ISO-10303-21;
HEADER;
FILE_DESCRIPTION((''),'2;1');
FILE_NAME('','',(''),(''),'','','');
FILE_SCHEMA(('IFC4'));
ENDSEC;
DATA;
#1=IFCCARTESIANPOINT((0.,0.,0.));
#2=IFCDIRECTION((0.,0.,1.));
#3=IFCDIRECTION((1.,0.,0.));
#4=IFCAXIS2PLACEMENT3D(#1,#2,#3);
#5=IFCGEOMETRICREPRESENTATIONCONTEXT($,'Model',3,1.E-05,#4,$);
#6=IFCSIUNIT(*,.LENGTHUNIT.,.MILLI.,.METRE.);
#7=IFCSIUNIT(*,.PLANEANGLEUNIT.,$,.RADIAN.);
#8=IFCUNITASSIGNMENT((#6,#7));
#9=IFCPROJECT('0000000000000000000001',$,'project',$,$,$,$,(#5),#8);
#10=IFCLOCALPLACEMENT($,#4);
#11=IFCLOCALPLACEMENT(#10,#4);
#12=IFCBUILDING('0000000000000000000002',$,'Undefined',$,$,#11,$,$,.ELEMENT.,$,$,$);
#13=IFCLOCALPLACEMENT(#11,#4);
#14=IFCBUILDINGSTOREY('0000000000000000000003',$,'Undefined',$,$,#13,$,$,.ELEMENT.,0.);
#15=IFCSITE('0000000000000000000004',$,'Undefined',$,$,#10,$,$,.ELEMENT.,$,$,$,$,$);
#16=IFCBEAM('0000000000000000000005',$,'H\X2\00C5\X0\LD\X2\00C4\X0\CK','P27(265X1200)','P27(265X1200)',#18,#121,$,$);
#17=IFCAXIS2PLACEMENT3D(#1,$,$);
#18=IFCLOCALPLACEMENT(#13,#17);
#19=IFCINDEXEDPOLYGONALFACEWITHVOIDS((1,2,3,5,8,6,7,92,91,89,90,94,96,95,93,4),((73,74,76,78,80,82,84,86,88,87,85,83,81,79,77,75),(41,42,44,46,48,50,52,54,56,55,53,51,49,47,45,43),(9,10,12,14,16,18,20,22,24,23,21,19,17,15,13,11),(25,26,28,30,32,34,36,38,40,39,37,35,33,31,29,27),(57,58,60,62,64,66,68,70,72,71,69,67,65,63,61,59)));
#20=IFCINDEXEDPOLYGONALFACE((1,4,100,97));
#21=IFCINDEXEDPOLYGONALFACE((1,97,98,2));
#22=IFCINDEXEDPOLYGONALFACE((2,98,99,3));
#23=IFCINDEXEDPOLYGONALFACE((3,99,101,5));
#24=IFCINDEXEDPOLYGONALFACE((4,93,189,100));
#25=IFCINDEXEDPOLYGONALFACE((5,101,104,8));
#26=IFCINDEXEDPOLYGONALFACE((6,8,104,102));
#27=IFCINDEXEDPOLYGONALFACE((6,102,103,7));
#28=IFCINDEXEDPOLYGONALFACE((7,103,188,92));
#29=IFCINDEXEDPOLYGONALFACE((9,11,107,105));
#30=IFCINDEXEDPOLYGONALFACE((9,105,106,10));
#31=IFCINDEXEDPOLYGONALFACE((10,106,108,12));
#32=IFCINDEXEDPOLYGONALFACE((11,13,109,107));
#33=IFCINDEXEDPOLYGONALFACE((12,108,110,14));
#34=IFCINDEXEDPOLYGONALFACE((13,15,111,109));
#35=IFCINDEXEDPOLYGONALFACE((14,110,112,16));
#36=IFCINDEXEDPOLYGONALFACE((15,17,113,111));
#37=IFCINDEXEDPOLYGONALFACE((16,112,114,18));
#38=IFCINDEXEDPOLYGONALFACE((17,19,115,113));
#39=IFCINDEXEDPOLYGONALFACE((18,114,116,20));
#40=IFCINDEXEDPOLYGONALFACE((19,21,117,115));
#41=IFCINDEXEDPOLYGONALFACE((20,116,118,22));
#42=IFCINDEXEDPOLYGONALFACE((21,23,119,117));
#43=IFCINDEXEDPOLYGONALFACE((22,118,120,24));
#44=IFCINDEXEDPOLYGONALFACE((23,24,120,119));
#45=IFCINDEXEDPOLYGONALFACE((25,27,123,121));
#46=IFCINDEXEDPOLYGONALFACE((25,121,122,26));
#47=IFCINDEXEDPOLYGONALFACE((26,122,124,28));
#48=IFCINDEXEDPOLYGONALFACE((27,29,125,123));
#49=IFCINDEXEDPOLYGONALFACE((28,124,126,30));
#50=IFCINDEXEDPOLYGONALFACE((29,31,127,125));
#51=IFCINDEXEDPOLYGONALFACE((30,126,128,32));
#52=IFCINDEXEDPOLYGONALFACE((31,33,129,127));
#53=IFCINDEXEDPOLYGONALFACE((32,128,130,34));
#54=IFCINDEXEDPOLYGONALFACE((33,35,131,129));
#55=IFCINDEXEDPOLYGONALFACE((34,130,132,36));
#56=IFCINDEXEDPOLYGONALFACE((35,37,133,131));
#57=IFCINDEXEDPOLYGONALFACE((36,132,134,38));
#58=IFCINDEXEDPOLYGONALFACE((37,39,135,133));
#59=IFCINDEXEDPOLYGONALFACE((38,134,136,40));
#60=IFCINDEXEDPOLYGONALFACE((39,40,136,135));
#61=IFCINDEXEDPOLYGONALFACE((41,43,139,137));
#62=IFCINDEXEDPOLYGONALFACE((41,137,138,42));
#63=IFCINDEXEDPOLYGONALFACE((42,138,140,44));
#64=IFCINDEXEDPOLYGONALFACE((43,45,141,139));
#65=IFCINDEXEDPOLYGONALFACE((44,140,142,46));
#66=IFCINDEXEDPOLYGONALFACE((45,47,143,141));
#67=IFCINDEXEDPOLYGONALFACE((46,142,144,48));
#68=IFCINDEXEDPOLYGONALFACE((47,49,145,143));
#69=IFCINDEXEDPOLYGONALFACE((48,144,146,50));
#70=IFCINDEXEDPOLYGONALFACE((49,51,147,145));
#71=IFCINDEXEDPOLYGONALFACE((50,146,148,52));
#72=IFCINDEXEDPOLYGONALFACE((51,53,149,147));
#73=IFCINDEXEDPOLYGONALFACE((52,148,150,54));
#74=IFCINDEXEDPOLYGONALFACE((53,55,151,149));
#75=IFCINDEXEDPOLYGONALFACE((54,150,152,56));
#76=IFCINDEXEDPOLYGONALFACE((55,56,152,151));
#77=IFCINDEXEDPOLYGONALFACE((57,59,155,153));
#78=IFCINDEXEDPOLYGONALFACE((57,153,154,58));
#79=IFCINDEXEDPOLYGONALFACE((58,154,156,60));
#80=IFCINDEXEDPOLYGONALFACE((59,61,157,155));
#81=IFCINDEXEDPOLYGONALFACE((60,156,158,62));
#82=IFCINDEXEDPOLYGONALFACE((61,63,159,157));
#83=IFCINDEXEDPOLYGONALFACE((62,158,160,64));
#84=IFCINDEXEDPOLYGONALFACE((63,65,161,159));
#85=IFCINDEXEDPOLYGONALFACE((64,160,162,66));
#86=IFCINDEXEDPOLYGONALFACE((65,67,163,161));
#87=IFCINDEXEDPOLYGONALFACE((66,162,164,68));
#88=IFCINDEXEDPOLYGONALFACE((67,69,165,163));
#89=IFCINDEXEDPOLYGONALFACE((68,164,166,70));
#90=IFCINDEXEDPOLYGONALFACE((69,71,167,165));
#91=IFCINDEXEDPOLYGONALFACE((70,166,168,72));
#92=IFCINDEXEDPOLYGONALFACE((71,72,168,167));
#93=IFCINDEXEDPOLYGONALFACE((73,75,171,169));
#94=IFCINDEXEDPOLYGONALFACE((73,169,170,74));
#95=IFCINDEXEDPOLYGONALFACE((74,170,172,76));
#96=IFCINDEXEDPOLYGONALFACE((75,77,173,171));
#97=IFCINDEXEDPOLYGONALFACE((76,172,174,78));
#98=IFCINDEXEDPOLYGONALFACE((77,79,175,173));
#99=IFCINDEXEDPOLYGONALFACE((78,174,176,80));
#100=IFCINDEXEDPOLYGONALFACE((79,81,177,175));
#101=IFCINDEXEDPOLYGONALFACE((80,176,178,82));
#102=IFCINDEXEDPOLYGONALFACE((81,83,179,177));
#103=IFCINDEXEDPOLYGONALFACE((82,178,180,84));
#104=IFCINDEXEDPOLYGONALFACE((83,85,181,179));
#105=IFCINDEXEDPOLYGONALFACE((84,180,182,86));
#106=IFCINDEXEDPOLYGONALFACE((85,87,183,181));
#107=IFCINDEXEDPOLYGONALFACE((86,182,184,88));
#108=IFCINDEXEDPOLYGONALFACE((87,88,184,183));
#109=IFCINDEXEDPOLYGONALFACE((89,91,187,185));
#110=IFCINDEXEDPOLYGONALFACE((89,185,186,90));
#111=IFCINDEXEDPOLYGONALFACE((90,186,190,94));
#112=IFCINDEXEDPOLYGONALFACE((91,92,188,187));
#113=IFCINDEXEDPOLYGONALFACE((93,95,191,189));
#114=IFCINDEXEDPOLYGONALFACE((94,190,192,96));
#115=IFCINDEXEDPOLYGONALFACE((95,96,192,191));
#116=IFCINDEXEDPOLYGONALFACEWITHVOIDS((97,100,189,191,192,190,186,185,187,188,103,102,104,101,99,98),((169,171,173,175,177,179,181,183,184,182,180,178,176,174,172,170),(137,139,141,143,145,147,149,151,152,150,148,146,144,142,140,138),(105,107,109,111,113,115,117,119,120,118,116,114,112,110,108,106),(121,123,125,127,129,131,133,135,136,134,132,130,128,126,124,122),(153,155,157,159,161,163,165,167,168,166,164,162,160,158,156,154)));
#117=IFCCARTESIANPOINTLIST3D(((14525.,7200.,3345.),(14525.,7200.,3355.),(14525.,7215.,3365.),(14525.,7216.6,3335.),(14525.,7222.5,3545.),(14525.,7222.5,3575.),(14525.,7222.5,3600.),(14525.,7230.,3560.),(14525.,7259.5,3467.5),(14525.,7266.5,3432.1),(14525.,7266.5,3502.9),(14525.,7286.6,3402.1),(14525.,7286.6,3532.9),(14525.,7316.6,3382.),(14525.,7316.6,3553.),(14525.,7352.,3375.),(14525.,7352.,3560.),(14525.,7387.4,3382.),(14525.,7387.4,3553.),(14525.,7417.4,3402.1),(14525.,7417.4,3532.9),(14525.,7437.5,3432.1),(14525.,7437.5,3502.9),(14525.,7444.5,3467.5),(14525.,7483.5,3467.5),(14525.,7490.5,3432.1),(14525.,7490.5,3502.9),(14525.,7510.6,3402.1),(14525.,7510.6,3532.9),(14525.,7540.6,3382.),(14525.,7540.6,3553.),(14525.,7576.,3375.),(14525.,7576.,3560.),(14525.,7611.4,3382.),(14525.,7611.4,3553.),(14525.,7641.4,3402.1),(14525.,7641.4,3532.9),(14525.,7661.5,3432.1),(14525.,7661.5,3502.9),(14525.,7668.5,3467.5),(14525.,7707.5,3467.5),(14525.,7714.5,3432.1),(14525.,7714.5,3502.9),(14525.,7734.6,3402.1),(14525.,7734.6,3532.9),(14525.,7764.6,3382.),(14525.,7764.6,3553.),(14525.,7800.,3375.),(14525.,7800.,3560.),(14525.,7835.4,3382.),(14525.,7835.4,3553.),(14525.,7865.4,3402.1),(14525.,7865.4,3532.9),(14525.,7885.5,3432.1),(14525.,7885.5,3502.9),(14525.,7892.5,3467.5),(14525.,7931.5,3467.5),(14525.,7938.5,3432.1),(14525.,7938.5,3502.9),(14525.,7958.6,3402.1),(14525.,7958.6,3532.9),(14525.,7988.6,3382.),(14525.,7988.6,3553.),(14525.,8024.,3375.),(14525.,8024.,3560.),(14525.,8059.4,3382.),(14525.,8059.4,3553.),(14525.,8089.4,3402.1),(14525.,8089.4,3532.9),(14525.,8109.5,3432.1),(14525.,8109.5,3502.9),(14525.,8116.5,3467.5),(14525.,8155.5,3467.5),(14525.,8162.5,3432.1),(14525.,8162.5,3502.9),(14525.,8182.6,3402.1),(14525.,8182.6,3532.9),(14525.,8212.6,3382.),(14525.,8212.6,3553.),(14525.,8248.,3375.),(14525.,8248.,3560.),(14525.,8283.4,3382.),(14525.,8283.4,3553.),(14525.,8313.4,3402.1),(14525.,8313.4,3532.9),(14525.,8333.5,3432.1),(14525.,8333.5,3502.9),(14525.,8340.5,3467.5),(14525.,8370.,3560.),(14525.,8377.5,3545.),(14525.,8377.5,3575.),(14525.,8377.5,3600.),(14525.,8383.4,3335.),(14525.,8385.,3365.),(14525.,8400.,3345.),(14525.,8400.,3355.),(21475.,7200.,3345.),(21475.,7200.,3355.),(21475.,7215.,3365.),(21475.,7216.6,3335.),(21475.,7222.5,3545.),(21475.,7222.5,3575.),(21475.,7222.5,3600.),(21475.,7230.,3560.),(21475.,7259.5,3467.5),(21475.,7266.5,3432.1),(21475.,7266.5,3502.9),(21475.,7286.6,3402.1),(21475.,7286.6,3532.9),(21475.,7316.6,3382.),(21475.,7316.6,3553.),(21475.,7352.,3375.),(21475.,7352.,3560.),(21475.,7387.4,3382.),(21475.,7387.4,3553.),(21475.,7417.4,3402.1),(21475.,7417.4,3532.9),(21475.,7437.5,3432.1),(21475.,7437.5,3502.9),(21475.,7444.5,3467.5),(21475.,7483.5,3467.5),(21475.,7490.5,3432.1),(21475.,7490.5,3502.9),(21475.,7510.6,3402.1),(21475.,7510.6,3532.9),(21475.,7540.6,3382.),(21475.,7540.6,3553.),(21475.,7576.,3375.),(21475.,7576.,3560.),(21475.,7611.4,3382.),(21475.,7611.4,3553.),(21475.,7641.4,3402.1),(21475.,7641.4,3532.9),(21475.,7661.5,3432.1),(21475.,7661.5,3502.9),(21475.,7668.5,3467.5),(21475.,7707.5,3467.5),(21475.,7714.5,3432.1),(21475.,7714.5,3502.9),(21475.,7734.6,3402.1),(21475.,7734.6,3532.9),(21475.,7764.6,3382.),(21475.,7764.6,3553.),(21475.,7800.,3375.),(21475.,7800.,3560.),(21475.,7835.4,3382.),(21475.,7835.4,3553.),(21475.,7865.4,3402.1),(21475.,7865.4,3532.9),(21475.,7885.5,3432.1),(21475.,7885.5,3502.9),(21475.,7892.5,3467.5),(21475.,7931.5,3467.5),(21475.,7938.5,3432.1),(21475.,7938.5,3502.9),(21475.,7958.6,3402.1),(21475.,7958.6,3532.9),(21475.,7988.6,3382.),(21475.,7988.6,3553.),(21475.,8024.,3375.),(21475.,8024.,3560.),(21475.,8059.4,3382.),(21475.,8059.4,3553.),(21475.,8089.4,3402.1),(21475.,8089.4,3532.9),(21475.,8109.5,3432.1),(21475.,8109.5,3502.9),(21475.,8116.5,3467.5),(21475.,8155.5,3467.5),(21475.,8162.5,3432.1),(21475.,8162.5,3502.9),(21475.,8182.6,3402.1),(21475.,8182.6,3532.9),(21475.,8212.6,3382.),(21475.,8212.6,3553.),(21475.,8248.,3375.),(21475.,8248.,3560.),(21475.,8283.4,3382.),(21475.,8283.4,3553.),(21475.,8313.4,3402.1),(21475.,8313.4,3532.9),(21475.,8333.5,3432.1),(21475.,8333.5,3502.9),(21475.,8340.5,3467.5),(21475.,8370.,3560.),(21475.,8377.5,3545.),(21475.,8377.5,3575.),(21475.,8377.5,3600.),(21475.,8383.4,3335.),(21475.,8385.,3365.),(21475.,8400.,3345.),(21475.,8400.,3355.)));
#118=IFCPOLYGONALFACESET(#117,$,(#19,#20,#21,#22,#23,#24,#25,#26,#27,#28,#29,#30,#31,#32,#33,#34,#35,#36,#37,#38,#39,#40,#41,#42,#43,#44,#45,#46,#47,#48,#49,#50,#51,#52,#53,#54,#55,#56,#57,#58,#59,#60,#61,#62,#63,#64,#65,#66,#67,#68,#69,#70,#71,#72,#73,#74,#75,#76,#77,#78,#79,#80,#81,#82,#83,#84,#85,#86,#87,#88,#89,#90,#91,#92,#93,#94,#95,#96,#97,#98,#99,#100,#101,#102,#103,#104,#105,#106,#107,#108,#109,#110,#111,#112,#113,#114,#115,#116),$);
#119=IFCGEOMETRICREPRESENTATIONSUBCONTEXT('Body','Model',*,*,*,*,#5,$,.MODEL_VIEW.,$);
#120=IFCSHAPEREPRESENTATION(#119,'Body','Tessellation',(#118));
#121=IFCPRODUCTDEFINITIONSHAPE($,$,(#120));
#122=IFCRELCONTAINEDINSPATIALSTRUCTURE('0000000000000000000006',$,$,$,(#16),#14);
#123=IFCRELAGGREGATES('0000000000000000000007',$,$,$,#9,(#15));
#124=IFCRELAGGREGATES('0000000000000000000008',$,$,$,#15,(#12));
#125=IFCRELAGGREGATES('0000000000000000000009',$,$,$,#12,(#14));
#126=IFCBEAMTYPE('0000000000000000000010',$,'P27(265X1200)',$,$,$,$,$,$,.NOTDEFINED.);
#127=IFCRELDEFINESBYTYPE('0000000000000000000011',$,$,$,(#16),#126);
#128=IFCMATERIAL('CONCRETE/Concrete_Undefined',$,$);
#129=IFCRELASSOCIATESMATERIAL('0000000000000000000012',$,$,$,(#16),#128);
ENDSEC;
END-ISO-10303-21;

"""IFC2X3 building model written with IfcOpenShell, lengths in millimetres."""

from ifc_helpers import new_model, si_unit, frame, origin_with_axes, place, context, subcontext, project, spatial, polyline, outline, extrude, material, type_object, element, save


model = new_model("IFC2X3")

# Units and contexts
model_context = context("Model", 3, precision=1e-05, world=origin_with_axes())
body_context = subcontext(model_context, "Body", "Model", "MODEL_VIEW")
ifc_project = project(units=[si_unit("LENGTHUNIT", "METRE", prefix="MILLI"), si_unit("PLANEANGLEUNIT", "RADIAN")], contexts=[model_context])

# Site, building, storey
site_placement = place(None, origin_with_axes())
site = spatial("IfcSite", under=ifc_project, at=site_placement, Name="Undefined", CompositionType="ELEMENT")
building_placement = place(site_placement, origin_with_axes())
building = spatial("IfcBuilding", under=site, at=building_placement, Name="Undefined", CompositionType="ELEMENT")
storey_placement = place(building_placement, origin_with_axes())
storey = spatial("IfcBuildingStorey", under=building, at=storey_placement, Name="Undefined", CompositionType="ELEMENT", Elevation=0.0)

# Beam
ifc_material_1 = material(Name="CONCRETE/Concrete_Undefined")
beam_type_1 = type_object("IfcBeamType", Name="P27(265X1200)", PredefinedType="NOTDEFINED")
beam_1_placement = place(storey_placement, frame((14525.0, 7800.0, 3467.5), z_axis=(0.0, 0.0, 1.0), x_axis=(1.0, 0.0, 0.0)))
element("IfcBeam", 1, at=beam_1_placement, inside=storey, type_object=beam_type_1, material=ifc_material_1, Name="HÅLDÄCK", Description="P27(265X1200)", ObjectType="P27(265X1200)", context=body_context, shape_type="SweptSolid", body=[
    extrude(outline(polyline([(-583.4, -132.5), (-600.0, -122.5), (-600.0, -112.5), (-585.0, -102.5), (-577.5, 77.5), (-570.0, 92.5), (-577.5, 107.5), (-577.5, 132.5), (577.5, 132.5), (577.5, 107.5), (570.0, 92.5), (577.5, 77.5), (585.0, -102.5), (600.0, -112.5), (600.0, -122.5), (583.4, -132.5), (-583.4, -132.5)]), holes=[polyline([(-513.4, 65.4), (-533.5, 35.4), (-540.5, 0.0), (-533.5, -35.4), (-513.4, -65.4), (-483.4, -85.5), (-448.0, -92.5), (-412.6, -85.5), (-382.6, -65.4), (-362.5, -35.4), (-355.5, 0.0), (-362.5, 35.4), (-382.6, 65.4), (-412.6, 85.5), (-448.0, 92.5), (-483.4, 85.5), (-513.4, 65.4)]), polyline([(-289.4, 65.4), (-309.5, 35.4), (-316.5, 0.0), (-309.5, -35.4), (-289.4, -65.4), (-259.4, -85.5), (-224.0, -92.5), (-188.6, -85.5), (-158.6, -65.4), (-138.5, -35.4), (-131.5, 0.0), (-138.5, 35.4), (-158.6, 65.4), (-188.6, 85.5), (-224.0, 92.5), (-259.4, 85.5), (-289.4, 65.4)]), polyline([(-65.4, 65.4), (-85.5, 35.4), (-92.5, 0.0), (-85.5, -35.4), (-65.4, -65.4), (-35.4, -85.5), (0.0, -92.5), (35.4, -85.5), (65.4, -65.4), (85.5, -35.4), (92.5, 0.0), (85.5, 35.4), (65.4, 65.4), (35.4, 85.5), (0.0, 92.5), (-35.4, 85.5), (-65.4, 65.4)]), polyline([(158.6, 65.4), (138.5, 35.4), (131.5, 0.0), (138.5, -35.4), (158.6, -65.4), (188.6, -85.5), (224.0, -92.5), (259.4, -85.5), (289.4, -65.4), (309.5, -35.4), (316.5, 0.0), (309.5, 35.4), (289.4, 65.4), (259.4, 85.5), (224.0, 92.5), (188.6, 85.5), (158.6, 65.4)]), polyline([(382.6, 65.4), (362.5, 35.4), (355.5, 0.0), (362.5, -35.4), (382.6, -65.4), (412.6, -85.5), (448.0, -92.5), (483.4, -85.5), (513.4, -65.4), (533.5, -35.4), (540.5, 0.0), (533.5, 35.4), (513.4, 65.4), (483.4, 85.5), (448.0, 92.5), (412.6, 85.5), (382.6, 65.4)])]), frame((6950.0, 0.0, 0.0), z_axis=(-1.0, 0.0, 0.0), x_axis=(0.0, -1.0, 0.0)), (0.0, 0.0, 1.0), 6950.0),
])

save(model, "model.ifc")
